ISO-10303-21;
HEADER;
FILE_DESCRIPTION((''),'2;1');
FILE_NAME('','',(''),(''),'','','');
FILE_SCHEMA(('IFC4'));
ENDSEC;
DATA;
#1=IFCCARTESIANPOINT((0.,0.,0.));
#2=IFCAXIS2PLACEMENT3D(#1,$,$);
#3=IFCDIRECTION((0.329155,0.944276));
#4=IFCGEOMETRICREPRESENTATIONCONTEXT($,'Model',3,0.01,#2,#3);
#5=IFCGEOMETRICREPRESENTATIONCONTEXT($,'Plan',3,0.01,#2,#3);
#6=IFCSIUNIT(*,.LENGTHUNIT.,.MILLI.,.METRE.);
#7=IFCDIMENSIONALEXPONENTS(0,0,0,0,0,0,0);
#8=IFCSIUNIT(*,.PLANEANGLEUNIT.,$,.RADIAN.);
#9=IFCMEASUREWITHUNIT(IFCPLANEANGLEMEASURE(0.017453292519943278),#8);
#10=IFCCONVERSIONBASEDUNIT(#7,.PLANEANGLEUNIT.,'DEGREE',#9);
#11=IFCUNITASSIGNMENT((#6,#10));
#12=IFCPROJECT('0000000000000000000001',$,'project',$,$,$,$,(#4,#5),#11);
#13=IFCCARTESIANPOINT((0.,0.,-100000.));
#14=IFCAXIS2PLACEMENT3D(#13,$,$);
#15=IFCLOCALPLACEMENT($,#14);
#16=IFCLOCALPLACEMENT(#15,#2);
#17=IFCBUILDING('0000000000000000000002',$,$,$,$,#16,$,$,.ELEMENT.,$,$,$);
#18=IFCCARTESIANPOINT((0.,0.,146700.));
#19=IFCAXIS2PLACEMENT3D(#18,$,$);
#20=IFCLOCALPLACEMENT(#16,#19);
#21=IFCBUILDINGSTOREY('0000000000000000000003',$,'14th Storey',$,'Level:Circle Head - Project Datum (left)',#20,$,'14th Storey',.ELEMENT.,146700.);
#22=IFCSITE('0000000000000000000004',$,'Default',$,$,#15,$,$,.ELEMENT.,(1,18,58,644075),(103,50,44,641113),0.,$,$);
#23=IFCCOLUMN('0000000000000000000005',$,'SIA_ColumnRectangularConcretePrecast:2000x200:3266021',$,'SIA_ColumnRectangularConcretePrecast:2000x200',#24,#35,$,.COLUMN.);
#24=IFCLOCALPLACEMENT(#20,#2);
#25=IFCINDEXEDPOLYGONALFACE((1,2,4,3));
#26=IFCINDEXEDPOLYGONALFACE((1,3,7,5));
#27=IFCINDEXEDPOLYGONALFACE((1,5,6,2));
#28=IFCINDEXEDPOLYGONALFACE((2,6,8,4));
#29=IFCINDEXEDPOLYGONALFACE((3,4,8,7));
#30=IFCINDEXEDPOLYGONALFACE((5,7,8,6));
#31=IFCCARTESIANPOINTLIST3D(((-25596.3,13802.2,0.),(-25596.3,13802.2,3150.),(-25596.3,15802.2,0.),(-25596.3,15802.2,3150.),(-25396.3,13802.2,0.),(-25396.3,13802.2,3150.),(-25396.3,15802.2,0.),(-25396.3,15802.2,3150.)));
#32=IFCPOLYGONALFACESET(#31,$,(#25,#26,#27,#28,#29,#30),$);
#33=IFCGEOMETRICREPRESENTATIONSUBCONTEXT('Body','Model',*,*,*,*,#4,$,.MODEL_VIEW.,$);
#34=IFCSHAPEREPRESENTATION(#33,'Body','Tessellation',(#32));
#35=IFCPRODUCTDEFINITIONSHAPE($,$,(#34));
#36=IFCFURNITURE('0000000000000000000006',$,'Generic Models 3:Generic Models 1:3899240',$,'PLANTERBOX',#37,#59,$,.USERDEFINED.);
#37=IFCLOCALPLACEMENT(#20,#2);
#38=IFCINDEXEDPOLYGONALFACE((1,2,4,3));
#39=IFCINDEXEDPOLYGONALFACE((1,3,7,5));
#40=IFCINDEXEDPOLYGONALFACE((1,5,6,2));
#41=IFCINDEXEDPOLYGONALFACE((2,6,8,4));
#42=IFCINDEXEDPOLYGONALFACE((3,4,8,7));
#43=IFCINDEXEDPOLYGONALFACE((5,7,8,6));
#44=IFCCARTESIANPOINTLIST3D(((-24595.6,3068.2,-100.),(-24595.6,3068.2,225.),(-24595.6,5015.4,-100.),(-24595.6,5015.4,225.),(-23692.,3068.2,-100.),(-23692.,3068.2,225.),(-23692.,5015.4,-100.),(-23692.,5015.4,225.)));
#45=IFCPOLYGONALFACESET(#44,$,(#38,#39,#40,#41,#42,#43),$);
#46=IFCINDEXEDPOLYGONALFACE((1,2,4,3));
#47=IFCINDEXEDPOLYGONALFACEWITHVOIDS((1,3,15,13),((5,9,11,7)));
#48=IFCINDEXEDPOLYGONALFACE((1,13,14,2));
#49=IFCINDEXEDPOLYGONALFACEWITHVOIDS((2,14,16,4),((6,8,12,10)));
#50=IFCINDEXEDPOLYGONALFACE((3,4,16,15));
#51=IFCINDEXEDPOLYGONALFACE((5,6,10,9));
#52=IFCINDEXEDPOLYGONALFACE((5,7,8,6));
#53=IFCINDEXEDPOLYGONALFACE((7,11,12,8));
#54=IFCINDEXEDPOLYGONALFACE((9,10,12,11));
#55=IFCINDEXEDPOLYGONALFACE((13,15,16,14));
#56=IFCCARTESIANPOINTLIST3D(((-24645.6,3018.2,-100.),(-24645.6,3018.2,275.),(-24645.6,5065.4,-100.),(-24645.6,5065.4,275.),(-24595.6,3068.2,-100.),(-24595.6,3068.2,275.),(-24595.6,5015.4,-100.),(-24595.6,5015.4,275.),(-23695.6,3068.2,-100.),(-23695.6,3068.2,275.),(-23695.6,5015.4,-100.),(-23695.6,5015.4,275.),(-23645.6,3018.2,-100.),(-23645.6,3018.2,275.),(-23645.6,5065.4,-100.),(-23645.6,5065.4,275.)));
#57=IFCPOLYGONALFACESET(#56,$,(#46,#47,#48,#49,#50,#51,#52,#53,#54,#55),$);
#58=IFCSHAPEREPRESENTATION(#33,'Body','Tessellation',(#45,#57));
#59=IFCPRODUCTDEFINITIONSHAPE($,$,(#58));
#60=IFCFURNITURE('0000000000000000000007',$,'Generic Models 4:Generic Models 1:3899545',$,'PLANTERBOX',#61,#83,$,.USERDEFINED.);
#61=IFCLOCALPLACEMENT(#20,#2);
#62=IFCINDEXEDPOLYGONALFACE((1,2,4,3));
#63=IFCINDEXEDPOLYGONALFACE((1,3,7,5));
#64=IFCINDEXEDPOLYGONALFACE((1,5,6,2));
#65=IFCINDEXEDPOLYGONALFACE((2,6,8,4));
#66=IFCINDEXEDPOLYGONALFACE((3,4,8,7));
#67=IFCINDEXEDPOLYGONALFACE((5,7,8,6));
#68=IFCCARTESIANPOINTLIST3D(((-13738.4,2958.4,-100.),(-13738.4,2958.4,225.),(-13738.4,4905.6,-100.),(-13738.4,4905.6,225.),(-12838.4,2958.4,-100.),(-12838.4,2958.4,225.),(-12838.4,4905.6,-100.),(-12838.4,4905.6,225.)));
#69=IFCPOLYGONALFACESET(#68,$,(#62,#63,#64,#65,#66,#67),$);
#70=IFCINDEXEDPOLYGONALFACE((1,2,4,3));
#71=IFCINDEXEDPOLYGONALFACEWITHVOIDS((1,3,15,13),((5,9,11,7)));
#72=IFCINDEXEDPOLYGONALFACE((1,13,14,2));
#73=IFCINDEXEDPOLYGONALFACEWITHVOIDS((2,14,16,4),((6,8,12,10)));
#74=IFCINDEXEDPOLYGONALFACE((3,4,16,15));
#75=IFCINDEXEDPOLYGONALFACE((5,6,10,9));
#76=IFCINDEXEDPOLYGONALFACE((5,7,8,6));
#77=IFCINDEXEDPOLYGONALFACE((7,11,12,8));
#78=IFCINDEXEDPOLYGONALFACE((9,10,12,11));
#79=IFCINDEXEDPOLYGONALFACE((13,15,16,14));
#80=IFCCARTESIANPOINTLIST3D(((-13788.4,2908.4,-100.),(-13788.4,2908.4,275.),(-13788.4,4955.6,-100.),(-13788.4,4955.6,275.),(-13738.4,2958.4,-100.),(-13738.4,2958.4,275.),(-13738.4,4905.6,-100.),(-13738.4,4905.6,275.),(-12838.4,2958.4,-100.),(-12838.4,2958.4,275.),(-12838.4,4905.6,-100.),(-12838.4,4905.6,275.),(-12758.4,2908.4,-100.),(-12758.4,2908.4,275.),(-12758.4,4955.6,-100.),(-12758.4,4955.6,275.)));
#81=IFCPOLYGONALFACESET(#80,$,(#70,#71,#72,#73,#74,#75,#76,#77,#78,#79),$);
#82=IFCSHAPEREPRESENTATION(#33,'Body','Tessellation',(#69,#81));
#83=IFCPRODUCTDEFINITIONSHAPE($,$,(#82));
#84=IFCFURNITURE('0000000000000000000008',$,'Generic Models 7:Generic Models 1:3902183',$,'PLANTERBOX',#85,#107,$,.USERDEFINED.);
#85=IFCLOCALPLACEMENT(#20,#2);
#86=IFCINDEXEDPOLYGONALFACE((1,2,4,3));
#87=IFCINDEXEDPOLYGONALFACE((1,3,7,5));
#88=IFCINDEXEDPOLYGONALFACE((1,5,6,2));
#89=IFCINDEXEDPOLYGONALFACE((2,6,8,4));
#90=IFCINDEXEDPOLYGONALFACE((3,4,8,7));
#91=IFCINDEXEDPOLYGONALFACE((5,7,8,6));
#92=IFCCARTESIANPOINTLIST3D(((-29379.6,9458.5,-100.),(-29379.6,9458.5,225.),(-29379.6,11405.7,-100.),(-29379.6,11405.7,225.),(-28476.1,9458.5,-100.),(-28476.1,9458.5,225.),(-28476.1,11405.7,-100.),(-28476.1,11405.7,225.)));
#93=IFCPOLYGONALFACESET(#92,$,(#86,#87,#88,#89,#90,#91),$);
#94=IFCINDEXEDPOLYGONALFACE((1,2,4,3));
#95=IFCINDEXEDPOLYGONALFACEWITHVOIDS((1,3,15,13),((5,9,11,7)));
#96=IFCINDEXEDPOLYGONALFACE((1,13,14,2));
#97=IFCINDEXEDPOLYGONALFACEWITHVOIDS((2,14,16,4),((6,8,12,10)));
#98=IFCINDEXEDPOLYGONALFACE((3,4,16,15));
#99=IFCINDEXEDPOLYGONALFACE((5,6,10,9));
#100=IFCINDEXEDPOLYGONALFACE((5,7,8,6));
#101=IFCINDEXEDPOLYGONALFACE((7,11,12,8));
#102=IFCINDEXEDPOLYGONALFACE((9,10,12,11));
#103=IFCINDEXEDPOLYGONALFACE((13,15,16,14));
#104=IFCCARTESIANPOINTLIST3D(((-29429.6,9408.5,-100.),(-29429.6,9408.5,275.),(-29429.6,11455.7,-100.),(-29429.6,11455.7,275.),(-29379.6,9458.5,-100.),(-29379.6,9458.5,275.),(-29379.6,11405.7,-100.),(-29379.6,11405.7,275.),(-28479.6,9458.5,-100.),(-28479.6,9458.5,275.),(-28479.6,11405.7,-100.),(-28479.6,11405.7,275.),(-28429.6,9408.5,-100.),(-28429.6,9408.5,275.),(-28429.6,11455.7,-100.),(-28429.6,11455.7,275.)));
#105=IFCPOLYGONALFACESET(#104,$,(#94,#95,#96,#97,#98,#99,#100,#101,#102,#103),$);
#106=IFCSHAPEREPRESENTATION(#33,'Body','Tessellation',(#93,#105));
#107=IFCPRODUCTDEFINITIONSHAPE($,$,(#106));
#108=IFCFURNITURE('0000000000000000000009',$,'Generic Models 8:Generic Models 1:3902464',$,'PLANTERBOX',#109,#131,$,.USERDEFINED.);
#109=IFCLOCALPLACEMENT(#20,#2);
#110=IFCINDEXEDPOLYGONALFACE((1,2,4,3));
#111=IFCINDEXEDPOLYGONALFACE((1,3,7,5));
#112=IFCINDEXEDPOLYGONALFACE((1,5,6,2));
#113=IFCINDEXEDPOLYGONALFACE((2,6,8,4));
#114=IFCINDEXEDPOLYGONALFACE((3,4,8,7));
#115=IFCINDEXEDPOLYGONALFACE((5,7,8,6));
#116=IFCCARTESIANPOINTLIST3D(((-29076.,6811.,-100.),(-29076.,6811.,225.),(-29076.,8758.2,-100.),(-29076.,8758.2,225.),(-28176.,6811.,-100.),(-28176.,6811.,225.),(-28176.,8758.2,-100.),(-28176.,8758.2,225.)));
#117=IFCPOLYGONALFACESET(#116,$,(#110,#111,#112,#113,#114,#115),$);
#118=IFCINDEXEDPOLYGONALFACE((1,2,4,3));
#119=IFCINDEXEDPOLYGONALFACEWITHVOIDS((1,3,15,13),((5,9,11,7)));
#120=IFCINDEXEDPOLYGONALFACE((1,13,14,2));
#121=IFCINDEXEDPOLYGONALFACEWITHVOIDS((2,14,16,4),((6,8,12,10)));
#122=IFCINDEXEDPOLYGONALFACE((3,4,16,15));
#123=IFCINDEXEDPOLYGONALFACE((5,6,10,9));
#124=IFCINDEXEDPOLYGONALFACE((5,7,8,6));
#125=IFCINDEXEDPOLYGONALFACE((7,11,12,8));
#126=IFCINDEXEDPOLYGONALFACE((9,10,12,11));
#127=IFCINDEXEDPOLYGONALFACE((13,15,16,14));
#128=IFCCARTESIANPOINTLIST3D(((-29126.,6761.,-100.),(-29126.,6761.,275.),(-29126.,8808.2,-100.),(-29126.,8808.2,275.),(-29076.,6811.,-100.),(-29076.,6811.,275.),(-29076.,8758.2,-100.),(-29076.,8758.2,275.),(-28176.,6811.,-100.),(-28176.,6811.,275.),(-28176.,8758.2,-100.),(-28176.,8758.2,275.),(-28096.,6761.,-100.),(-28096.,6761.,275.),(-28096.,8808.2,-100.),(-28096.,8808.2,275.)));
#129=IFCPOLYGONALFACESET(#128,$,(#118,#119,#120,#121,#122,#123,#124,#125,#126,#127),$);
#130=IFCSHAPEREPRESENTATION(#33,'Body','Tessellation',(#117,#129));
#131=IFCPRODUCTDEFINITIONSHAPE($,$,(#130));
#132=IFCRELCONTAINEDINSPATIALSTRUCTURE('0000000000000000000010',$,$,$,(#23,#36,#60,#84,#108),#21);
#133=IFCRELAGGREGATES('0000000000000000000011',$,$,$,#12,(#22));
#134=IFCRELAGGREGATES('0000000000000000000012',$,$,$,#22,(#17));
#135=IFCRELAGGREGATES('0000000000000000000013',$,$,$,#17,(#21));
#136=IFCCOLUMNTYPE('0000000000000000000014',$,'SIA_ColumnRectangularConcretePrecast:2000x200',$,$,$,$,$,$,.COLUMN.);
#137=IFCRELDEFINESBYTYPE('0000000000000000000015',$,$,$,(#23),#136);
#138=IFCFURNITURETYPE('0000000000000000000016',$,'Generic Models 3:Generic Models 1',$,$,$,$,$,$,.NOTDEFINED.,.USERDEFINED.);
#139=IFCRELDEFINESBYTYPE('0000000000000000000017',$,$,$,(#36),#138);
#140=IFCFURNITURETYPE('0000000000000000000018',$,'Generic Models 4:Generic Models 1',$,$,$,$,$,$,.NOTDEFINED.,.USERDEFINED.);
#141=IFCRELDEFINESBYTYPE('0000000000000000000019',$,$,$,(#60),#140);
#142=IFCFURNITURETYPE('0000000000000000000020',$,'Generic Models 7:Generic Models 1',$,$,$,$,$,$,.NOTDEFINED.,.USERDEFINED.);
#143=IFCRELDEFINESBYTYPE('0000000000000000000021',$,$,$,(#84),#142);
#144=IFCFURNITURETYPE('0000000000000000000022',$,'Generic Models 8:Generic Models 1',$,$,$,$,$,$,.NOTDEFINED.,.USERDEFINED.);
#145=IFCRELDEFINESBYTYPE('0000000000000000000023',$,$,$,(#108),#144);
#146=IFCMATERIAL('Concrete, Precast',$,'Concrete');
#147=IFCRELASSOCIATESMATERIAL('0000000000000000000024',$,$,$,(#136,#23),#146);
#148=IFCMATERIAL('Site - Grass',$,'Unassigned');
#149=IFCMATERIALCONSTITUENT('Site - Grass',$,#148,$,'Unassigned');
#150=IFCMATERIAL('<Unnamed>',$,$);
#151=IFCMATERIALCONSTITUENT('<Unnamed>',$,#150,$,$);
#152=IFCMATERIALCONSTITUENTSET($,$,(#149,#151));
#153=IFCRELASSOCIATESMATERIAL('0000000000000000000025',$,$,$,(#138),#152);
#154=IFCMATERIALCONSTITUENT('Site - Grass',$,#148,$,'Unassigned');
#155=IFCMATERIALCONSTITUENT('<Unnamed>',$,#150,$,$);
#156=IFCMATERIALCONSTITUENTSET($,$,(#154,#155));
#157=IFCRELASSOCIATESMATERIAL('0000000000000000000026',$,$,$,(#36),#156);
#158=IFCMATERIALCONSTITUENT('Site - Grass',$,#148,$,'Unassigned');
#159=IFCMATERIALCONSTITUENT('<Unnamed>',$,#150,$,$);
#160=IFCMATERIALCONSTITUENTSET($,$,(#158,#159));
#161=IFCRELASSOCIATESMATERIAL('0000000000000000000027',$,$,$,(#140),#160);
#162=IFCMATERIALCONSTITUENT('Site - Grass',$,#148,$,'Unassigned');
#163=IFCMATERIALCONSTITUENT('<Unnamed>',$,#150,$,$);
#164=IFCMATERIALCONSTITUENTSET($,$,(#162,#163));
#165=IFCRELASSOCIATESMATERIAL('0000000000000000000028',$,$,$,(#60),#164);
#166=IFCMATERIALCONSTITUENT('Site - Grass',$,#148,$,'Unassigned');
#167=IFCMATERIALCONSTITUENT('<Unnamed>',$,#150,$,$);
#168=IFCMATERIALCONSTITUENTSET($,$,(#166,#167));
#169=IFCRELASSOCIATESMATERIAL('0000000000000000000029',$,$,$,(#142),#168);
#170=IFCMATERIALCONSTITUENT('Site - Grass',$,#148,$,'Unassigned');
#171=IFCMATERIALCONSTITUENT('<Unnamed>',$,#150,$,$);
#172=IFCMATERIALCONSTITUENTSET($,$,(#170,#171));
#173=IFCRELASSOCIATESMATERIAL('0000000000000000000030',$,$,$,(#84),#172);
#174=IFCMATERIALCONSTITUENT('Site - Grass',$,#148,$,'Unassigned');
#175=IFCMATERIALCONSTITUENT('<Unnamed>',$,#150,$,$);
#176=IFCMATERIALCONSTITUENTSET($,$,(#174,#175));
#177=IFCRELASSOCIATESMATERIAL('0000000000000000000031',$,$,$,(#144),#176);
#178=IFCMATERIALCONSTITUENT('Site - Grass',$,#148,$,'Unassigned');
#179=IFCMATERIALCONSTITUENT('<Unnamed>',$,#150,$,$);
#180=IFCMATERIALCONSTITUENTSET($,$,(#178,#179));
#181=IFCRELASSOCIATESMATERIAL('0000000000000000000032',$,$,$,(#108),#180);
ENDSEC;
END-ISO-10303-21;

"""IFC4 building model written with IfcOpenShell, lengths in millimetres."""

from ifc_helpers import new_model, entity, si_unit, converted_unit, direction, frame, origin, place, context, subcontext, project, spatial, indexed_curve, outline, extrude, source, transform, mapped, material, constituent, constituent_set, type_object, type_shapes, element, save


model = new_model("IFC4")

# Units and contexts
model_context = context("Model", 3, precision=0.01, world=origin(), true_north=direction((0.329155, 0.944276)))
plan_context = context("Plan", 3, precision=0.01, world=origin(), true_north=direction((0.329155, 0.944276)))
body_context = subcontext(model_context, "Body", "Model", "MODEL_VIEW")
ifc_project = project(units=[si_unit("LENGTHUNIT", "METRE", prefix="MILLI"), converted_unit("PLANEANGLEUNIT", "DEGREE", entity("IfcPlaneAngleMeasure", 0.017453292519943278), si_unit("PLANEANGLEUNIT", "RADIAN"), dimensions=[0, 0, 0, 0, 0, 0, 0])], contexts=[model_context, plan_context])

# Site, building, storey
site_placement = place(None, frame((0.0, 0.0, -100000.0)))
site = spatial("IfcSite", under=ifc_project, at=site_placement, Name="Default", CompositionType="ELEMENT", RefLatitude=(1, 18, 58, 644075), RefLongitude=(103, 50, 44, 641113), RefElevation=0.0)
building_placement = place(site_placement, origin())
building = spatial("IfcBuilding", under=site, at=building_placement, CompositionType="ELEMENT")
storey_placement = place(building_placement, frame((0.0, 0.0, 146700.0)))
storey = spatial("IfcBuildingStorey", under=building, at=storey_placement, Name="14th Storey", ObjectType="Level:Circle Head - Project Datum (left)", LongName="14th Storey", CompositionType="ELEMENT", Elevation=146700.0)

# Column
ifc_material_1 = material(Name="Concrete, Precast", Category="Concrete")
column_type_1 = type_object("IfcColumnType", Name="SIA_ColumnRectangularConcretePrecast:2000x200", PredefinedType="COLUMN", material=ifc_material_1)
shared_shape_1 = source(origin(), body_context, "Body", "SweptSolid", [
    extrude(outline(indexed_curve([(-100.0, -1000.0), (100.0, -1000.0), (100.0, 1000.0), (-100.0, 1000.0), (-100.0, -1000.0)], self_intersect=False)), frame((0.0, 0.0, 146700.0), z_axis=(0.0, 0.0, 1.0), x_axis=(-1.0, 0.0, 0.0)), (0.0, 0.0, 1.0), 3150.0),
])
type_shapes(column_type_1, [shared_shape_1])
column_1_placement = place(storey_placement, frame((-25496.3, 14802.2, -146700.0)))
element("IfcColumn", 1, at=column_1_placement, inside=storey, type_object=column_type_1, material=ifc_material_1, Name="SIA_ColumnRectangularConcretePrecast:2000x200:3266021", ObjectType="SIA_ColumnRectangularConcretePrecast:2000x200", PredefinedType="COLUMN", context=body_context, shape_type="MappedRepresentation", body=[
    mapped(shared_shape_1, transform((0.0, 0.0, 0.0), scale=1.0)),
])

# Furniture
ifc_material_2 = material(Name="Site - Grass", Category="Unassigned")
ifc_material_3 = material(Name="<Unnamed>")
ifc_constituent_1 = constituent(ifc_material_2, Name="Site - Grass", Category="Unassigned")
ifc_constituent_2 = constituent(ifc_material_3, Name="<Unnamed>")
ifc_constituent_set_1 = constituent_set(constituents=[ifc_constituent_1, ifc_constituent_2])
ifc_constituent_3 = constituent(ifc_material_2, Name="Site - Grass", Category="Unassigned")
ifc_constituent_4 = constituent(ifc_material_3, Name="<Unnamed>")
ifc_constituent_set_2 = constituent_set(constituents=[ifc_constituent_3, ifc_constituent_4])
furniture_type_1 = type_object("IfcFurnitureType", Name="Generic Models 3:Generic Models 1", AssemblyPlace="NOTDEFINED", PredefinedType="USERDEFINED", material=ifc_constituent_set_2)
shared_shape_2 = source(origin(), body_context, "Body", "SweptSolid", [
    extrude(outline(indexed_curve([(-451.8, -973.6), (451.8, -973.6), (451.8, 973.6), (-451.8, 973.6), (-451.8, -973.6)], self_intersect=False)), frame((-24143.8, 4041.8, 146600.0), z_axis=(0.0, 0.0, 1.0), x_axis=(-1.0, 0.0, 0.0)), (0.0, 0.0, 1.0), 325.0),
    extrude(outline(indexed_curve([(-500.0, -1023.6), (500.0, -1023.6), (500.0, 1023.6), (-500.0, 1023.6), (-500.0, -1023.6)], self_intersect=False), holes=[indexed_curve([(-450.0, -973.6), (-450.0, 973.6), (450.0, 973.6), (450.0, -973.6), (-450.0, -973.6)], self_intersect=False)]), frame((-24145.6, 4041.8, 146600.0)), (0.0, 0.0, 1.0), 375.0),
])
type_shapes(furniture_type_1, [shared_shape_2])
furniture_1_placement = place(storey_placement, frame((0.0, 0.0, -146700.0)))
element("IfcFurniture", 2, at=furniture_1_placement, inside=storey, type_object=furniture_type_1, material=ifc_constituent_set_1, Name="Generic Models 3:Generic Models 1:3899240", ObjectType="PLANTERBOX", PredefinedType="USERDEFINED", context=body_context, shape_type="MappedRepresentation", body=[
    mapped(shared_shape_2, transform((0.0, 0.0, 0.0), scale=1.0)),
])
ifc_constituent_5 = constituent(ifc_material_2, Name="Site - Grass", Category="Unassigned")
ifc_constituent_6 = constituent(ifc_material_3, Name="<Unnamed>")
ifc_constituent_set_3 = constituent_set(constituents=[ifc_constituent_5, ifc_constituent_6])
ifc_constituent_7 = constituent(ifc_material_2, Name="Site - Grass", Category="Unassigned")
ifc_constituent_8 = constituent(ifc_material_3, Name="<Unnamed>")
ifc_constituent_set_4 = constituent_set(constituents=[ifc_constituent_7, ifc_constituent_8])
furniture_type_2 = type_object("IfcFurnitureType", Name="Generic Models 4:Generic Models 1", AssemblyPlace="NOTDEFINED", PredefinedType="USERDEFINED", material=ifc_constituent_set_4)
shared_shape_3 = source(origin(), body_context, "Body", "SweptSolid", [
    extrude(outline(indexed_curve([(-450.0, -973.6), (450.0, -973.6), (450.0, 973.6), (-450.0, 973.6), (-450.0, -973.6)], self_intersect=False)), frame((-13288.4, 3932.0, 146600.0), z_axis=(0.0, 0.0, 1.0), x_axis=(-1.0, 0.0, 0.0)), (0.0, 0.0, 1.0), 325.0),
    extrude(outline(indexed_curve([(-515.0, -1023.6), (515.0, -1023.6), (515.0, 1023.6), (-515.0, 1023.6), (-515.0, -1023.6)], self_intersect=False), holes=[indexed_curve([(-465.0, -973.6), (-465.0, 973.6), (435.0, 973.6), (435.0, -973.6), (-465.0, -973.6)], self_intersect=False)]), frame((-13273.4, 3932.0, 146600.0)), (0.0, 0.0, 1.0), 375.0),
])
type_shapes(furniture_type_2, [shared_shape_3])
furniture_2_placement = place(storey_placement, frame((0.0, 0.0, -146700.0)))
element("IfcFurniture", 3, at=furniture_2_placement, inside=storey, type_object=furniture_type_2, material=ifc_constituent_set_3, Name="Generic Models 4:Generic Models 1:3899545", ObjectType="PLANTERBOX", PredefinedType="USERDEFINED", context=body_context, shape_type="MappedRepresentation", body=[
    mapped(shared_shape_3, transform((0.0, 0.0, 0.0), scale=1.0)),
])
ifc_constituent_9 = constituent(ifc_material_2, Name="Site - Grass", Category="Unassigned")
ifc_constituent_10 = constituent(ifc_material_3, Name="<Unnamed>")
ifc_constituent_set_5 = constituent_set(constituents=[ifc_constituent_9, ifc_constituent_10])
ifc_constituent_11 = constituent(ifc_material_2, Name="Site - Grass", Category="Unassigned")
ifc_constituent_12 = constituent(ifc_material_3, Name="<Unnamed>")
ifc_constituent_set_6 = constituent_set(constituents=[ifc_constituent_11, ifc_constituent_12])
furniture_type_3 = type_object("IfcFurnitureType", Name="Generic Models 7:Generic Models 1", AssemblyPlace="NOTDEFINED", PredefinedType="USERDEFINED", material=ifc_constituent_set_6)
shared_shape_4 = source(origin(), body_context, "Body", "SweptSolid", [
    extrude(outline(indexed_curve([(-451.8, -973.6), (451.8, -973.6), (451.8, 973.6), (-451.8, 973.6), (-451.8, -973.6)], self_intersect=False)), frame((-28927.9, 10432.1, 146600.0), z_axis=(0.0, 0.0, 1.0), x_axis=(-1.0, 0.0, 0.0)), (0.0, 0.0, 1.0), 325.0),
    extrude(outline(indexed_curve([(-500.0, -1023.6), (500.0, -1023.6), (500.0, 1023.6), (-500.0, 1023.6), (-500.0, -1023.6)], self_intersect=False), holes=[indexed_curve([(-450.0, -973.6), (-450.0, 973.6), (450.0, 973.6), (450.0, -973.6), (-450.0, -973.6)], self_intersect=False)]), frame((-28929.6, 10432.1, 146600.0)), (0.0, 0.0, 1.0), 375.0),
])
type_shapes(furniture_type_3, [shared_shape_4])
furniture_3_placement = place(storey_placement, frame((0.0, 0.0, -146700.0)))
element("IfcFurniture", 4, at=furniture_3_placement, inside=storey, type_object=furniture_type_3, material=ifc_constituent_set_5, Name="Generic Models 7:Generic Models 1:3902183", ObjectType="PLANTERBOX", PredefinedType="USERDEFINED", context=body_context, shape_type="MappedRepresentation", body=[
    mapped(shared_shape_4, transform((0.0, 0.0, 0.0), scale=1.0)),
])
ifc_constituent_13 = constituent(ifc_material_2, Name="Site - Grass", Category="Unassigned")
ifc_constituent_14 = constituent(ifc_material_3, Name="<Unnamed>")
ifc_constituent_set_7 = constituent_set(constituents=[ifc_constituent_13, ifc_constituent_14])
ifc_constituent_15 = constituent(ifc_material_2, Name="Site - Grass", Category="Unassigned")
ifc_constituent_16 = constituent(ifc_material_3, Name="<Unnamed>")
ifc_constituent_set_8 = constituent_set(constituents=[ifc_constituent_15, ifc_constituent_16])
furniture_type_4 = type_object("IfcFurnitureType", Name="Generic Models 8:Generic Models 1", AssemblyPlace="NOTDEFINED", PredefinedType="USERDEFINED", material=ifc_constituent_set_8)
shared_shape_5 = source(origin(), body_context, "Body", "SweptSolid", [
    extrude(outline(indexed_curve([(-450.0, -973.6), (450.0, -973.6), (450.0, 973.6), (-450.0, 973.6), (-450.0, -973.6)], self_intersect=False)), frame((-28626.0, 7784.6, 146600.0), z_axis=(0.0, 0.0, 1.0), x_axis=(-1.0, 0.0, 0.0)), (0.0, 0.0, 1.0), 325.0),
    extrude(outline(indexed_curve([(-515.0, -1023.6), (515.0, -1023.6), (515.0, 1023.6), (-515.0, 1023.6), (-515.0, -1023.6)], self_intersect=False), holes=[indexed_curve([(-465.0, -973.6), (-465.0, 973.6), (435.0, 973.6), (435.0, -973.6), (-465.0, -973.6)], self_intersect=False)]), frame((-28611.0, 7784.6, 146600.0)), (0.0, 0.0, 1.0), 375.0),
])
type_shapes(furniture_type_4, [shared_shape_5])
furniture_4_placement = place(storey_placement, frame((0.0, 0.0, -146700.0)))
element("IfcFurniture", 5, at=furniture_4_placement, inside=storey, type_object=furniture_type_4, material=ifc_constituent_set_7, Name="Generic Models 8:Generic Models 1:3902464", ObjectType="PLANTERBOX", PredefinedType="USERDEFINED", context=body_context, shape_type="MappedRepresentation", body=[
    mapped(shared_shape_5, transform((0.0, 0.0, 0.0), scale=1.0)),
])

save(model, "model.ifc")
